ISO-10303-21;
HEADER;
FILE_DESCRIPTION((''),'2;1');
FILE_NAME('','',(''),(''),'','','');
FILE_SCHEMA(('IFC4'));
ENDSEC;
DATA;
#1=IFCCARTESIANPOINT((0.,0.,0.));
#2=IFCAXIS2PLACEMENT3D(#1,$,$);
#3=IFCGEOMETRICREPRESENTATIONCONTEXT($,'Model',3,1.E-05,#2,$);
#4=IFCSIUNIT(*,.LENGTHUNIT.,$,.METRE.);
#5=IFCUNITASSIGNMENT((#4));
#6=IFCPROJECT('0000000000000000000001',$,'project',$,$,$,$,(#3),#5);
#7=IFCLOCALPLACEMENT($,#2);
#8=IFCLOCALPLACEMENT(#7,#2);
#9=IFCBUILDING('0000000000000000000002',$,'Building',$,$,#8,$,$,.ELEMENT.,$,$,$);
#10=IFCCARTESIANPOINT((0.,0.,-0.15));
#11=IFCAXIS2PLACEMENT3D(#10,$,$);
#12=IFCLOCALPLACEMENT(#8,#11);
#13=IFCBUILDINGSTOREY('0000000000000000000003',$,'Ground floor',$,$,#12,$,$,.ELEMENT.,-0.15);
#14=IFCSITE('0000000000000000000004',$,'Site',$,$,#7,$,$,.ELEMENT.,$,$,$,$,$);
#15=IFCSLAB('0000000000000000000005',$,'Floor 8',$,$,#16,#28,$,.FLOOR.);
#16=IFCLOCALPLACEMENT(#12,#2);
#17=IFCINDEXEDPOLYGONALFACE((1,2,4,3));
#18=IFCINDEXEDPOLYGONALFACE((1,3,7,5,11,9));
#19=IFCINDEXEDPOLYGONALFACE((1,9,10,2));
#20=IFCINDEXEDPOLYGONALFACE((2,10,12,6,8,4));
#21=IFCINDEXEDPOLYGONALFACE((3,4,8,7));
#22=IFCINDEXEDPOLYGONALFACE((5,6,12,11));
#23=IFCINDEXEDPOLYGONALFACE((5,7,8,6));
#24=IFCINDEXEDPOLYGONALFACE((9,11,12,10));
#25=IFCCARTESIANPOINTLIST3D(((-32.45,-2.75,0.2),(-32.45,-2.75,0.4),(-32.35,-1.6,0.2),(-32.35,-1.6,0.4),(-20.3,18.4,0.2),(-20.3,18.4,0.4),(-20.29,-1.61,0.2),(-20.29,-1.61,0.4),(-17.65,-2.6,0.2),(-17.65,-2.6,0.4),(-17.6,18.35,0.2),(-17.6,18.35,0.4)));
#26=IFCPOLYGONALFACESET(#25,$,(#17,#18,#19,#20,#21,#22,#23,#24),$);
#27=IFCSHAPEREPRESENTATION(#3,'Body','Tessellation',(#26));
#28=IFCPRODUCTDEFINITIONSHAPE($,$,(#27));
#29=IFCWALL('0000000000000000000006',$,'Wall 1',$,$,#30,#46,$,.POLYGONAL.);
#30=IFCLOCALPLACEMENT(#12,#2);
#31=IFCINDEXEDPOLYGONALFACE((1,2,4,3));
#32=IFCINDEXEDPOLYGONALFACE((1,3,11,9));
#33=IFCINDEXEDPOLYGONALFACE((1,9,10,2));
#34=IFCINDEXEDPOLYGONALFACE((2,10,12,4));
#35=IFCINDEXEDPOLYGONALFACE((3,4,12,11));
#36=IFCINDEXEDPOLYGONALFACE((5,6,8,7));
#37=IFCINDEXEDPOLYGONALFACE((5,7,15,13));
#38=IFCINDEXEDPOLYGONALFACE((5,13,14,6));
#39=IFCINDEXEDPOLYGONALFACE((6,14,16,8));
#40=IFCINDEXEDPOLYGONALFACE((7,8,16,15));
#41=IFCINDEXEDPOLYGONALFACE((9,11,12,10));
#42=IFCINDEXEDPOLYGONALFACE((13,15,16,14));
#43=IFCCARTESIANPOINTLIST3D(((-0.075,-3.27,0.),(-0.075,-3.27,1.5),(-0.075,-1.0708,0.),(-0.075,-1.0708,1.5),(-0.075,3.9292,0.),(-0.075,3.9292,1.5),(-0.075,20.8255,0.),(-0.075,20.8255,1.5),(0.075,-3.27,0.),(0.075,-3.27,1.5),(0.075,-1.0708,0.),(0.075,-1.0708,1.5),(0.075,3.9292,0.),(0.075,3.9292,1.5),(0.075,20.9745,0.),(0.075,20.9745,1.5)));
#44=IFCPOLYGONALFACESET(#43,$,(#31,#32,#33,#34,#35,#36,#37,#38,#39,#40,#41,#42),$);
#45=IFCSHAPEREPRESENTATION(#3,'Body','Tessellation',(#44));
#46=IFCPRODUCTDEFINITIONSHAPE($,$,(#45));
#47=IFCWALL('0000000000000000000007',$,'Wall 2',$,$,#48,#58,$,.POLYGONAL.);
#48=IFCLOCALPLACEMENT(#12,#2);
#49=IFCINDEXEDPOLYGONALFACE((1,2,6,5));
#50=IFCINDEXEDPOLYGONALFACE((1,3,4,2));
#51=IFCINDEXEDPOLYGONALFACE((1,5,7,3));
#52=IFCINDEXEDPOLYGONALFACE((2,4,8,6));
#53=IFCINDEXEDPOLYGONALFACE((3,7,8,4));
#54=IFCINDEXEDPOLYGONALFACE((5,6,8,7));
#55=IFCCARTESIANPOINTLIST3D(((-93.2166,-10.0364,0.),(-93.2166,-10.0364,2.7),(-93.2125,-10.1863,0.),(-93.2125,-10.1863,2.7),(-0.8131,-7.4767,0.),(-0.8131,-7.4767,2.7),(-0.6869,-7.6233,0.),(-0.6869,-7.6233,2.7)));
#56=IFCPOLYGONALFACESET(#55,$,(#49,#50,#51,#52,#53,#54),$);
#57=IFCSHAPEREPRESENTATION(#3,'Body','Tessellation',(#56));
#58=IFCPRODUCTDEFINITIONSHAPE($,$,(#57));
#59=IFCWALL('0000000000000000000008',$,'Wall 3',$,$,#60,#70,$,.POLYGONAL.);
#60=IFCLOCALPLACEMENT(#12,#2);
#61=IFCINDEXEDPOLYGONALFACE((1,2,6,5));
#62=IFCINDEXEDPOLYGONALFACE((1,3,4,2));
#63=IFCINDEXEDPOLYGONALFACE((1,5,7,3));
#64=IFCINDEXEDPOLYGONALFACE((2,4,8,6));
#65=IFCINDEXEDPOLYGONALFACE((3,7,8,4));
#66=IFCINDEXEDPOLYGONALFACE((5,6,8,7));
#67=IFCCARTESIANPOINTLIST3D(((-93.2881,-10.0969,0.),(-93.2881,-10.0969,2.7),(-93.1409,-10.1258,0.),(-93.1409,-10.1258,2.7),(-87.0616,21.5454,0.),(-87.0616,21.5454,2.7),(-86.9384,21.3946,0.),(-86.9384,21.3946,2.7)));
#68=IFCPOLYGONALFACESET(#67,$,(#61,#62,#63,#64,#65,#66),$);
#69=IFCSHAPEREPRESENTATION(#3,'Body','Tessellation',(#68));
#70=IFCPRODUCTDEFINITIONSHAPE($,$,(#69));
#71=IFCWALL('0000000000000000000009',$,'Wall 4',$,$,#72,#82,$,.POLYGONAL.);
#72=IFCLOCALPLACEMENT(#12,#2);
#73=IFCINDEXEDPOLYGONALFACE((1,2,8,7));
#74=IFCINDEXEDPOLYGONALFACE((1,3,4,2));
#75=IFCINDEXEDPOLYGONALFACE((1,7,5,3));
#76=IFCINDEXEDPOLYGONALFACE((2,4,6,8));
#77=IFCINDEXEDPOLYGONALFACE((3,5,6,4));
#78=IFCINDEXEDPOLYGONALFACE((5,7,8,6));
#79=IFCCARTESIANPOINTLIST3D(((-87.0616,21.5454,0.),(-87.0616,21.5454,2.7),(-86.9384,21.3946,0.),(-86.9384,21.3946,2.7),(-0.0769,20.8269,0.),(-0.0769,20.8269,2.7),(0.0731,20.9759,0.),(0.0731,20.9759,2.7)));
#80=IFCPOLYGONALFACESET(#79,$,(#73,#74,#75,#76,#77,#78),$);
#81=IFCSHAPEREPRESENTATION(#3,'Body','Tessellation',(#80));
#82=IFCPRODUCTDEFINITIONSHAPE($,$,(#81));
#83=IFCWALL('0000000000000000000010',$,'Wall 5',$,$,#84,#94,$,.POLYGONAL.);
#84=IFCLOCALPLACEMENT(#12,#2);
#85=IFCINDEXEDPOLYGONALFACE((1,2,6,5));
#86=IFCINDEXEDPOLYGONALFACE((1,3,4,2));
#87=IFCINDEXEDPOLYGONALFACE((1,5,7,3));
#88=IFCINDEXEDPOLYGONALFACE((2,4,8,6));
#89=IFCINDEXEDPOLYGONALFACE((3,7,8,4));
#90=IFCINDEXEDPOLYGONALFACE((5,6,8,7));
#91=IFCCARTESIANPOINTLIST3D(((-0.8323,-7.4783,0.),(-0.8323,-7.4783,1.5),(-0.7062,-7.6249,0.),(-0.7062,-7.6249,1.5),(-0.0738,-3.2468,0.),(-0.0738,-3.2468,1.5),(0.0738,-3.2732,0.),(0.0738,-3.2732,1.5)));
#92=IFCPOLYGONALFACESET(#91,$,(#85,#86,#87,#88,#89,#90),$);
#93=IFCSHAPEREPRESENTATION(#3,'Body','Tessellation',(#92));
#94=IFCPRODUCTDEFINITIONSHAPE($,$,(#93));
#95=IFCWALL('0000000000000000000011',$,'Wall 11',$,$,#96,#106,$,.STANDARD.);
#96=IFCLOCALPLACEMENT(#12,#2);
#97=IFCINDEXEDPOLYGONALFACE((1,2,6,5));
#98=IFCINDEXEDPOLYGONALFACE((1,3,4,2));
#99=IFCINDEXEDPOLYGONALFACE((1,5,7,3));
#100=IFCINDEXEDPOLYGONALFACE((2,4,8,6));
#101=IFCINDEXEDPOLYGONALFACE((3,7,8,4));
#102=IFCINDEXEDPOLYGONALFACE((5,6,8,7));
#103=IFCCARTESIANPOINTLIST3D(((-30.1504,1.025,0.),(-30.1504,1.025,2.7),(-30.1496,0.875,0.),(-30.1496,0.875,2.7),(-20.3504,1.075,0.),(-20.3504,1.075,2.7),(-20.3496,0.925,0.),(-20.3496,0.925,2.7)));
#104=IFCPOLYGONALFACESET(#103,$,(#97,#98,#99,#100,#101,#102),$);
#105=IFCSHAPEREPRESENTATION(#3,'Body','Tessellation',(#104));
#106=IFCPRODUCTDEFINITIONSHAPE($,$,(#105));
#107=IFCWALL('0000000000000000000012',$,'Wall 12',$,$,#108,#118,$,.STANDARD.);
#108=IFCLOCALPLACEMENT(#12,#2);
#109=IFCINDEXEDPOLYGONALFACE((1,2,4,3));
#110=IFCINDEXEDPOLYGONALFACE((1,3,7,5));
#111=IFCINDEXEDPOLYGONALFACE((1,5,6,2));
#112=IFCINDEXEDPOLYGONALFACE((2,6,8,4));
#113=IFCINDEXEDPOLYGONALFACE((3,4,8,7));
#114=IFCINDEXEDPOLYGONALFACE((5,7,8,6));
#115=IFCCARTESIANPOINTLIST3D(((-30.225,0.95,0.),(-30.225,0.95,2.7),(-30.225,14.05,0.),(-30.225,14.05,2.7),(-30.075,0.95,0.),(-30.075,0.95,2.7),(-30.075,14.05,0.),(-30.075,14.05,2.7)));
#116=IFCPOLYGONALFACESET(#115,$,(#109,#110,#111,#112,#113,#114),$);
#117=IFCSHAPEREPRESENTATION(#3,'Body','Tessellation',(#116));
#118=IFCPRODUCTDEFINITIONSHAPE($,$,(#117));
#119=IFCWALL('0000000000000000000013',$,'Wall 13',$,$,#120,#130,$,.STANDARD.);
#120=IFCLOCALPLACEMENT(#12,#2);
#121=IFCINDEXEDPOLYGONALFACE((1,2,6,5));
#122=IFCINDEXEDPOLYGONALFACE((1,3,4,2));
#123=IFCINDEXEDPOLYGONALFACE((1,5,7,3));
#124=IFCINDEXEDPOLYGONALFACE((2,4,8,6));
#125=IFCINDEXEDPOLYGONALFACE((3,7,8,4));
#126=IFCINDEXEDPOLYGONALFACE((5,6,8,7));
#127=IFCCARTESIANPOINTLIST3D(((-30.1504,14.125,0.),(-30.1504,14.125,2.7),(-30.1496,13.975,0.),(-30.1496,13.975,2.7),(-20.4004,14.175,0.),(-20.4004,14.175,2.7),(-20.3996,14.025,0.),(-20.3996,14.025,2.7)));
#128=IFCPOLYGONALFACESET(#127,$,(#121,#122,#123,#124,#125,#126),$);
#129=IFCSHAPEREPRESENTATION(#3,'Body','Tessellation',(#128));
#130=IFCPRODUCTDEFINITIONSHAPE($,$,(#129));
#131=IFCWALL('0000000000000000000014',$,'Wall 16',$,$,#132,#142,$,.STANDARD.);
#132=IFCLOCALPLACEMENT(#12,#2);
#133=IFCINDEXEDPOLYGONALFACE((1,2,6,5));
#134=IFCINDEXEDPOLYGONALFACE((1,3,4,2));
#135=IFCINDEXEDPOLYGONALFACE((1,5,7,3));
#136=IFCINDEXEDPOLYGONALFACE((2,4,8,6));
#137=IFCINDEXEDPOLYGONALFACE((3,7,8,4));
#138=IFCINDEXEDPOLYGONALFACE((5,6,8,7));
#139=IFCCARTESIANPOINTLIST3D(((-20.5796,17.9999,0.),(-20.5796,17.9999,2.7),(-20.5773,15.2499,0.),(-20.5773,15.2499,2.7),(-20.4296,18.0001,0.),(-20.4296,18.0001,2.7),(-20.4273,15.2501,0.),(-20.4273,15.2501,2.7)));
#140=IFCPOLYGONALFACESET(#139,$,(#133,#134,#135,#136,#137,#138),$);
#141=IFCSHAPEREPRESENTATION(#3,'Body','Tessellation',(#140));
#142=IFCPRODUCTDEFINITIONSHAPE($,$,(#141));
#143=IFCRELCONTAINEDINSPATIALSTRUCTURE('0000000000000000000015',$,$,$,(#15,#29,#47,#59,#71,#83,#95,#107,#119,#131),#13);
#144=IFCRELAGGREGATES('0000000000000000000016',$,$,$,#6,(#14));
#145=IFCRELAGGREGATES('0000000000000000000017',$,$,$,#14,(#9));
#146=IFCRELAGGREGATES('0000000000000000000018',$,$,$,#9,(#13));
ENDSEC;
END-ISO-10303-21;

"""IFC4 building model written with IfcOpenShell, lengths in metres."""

from ifc_helpers import new_model, si_unit, frame, frame_2d, origin, origin_with_axes, place, context, project, spatial, polyline, rectangle, outline, extrude, element, save


model = new_model("IFC4")

# Units and contexts
model_context = context("Model", 3, precision=1e-05, world=origin())
ifc_project = project(units=[si_unit("LENGTHUNIT", "METRE")], contexts=[model_context])

# Site, building, storey
site_placement = place(None, origin())
site = spatial("IfcSite", under=ifc_project, at=site_placement, Name="Site", CompositionType="ELEMENT")
building_placement = place(site_placement, origin())
building = spatial("IfcBuilding", under=site, at=building_placement, Name="Building", CompositionType="ELEMENT")
storey_placement = place(building_placement, frame((0.0, 0.0, -0.15)))
storey = spatial("IfcBuildingStorey", under=building, at=storey_placement, Name="Ground floor", CompositionType="ELEMENT", Elevation=-0.15)

# Slab
slab_1_placement = place(storey_placement, frame((0.0, 0.0, 0.2), z_axis=(0.0, 0.0, 1.0), x_axis=(1.0, 0.0, 0.0)))
element("IfcSlab", 1, at=slab_1_placement, inside=storey, Name="Floor 8", PredefinedType="FLOOR", context=model_context, shape_type="SweptSolid", body=[
    extrude(outline(polyline([(-32.45, -2.75), (-32.35, -1.6), (-32.35, -1.6), (-20.29, -1.61), (-20.3, 18.4), (-17.6, 18.35), (-17.65, -2.6), (-32.45, -2.75)])), origin(), (0.0, 0.0, 1.0), 0.2),
])

# Wall, opening
wall_1_placement = place(storey_placement, origin_with_axes())
wall_1 = element("IfcWall", 2, at=wall_1_placement, inside=storey, Name="Wall 1", PredefinedType="POLYGONAL", context=model_context, shape_type="SweptSolid", body=[
    extrude(outline(polyline([(0.075, 20.9745), (-0.075, 20.8255), (-0.075, -3.27), (0.075, -3.27), (0.075, 20.9745)])), origin(), (0.0, 0.0, 1.0), 1.5),
])
opening_1_placement = place(storey_placement, frame((0.0, 3.9292, 0.0), z_axis=(0.0, 0.0, 1.0), x_axis=(0.0, -1.0, 0.0)))
element("IfcOpeningElement", 3, at=opening_1_placement, cuts=wall_1, PredefinedType="OPENING", context=model_context, shape_type="SweptSolid", body=[
    extrude(rectangle(XDim=5.0, YDim=0.21, at=frame_2d((2.5, 0.0))), origin(), (0.0, 0.0, 1.0), 2.1),
])

# Walls
wall_2_placement = place(storey_placement, origin_with_axes())
element("IfcWall", 4, at=wall_2_placement, inside=storey, Name="Wall 2", PredefinedType="POLYGONAL", context=model_context, shape_type="SweptSolid", body=[
    extrude(outline(polyline([(-0.6869, -7.6233), (-0.8131, -7.4767), (-93.2166, -10.0364), (-93.2125, -10.1863), (-0.6869, -7.6233)])), origin(), (0.0, 0.0, 1.0), 2.7),
])
wall_3_placement = place(storey_placement, origin_with_axes())
element("IfcWall", 5, at=wall_3_placement, inside=storey, Name="Wall 3", PredefinedType="POLYGONAL", context=model_context, shape_type="SweptSolid", body=[
    extrude(outline(polyline([(-93.2881, -10.0969), (-93.1409, -10.1258), (-86.9384, 21.3946), (-87.0616, 21.5454), (-93.2881, -10.0969)])), origin(), (0.0, 0.0, 1.0), 2.7),
])
wall_4_placement = place(storey_placement, origin_with_axes())
element("IfcWall", 6, at=wall_4_placement, inside=storey, Name="Wall 4", PredefinedType="POLYGONAL", context=model_context, shape_type="SweptSolid", body=[
    extrude(outline(polyline([(-87.0616, 21.5454), (-86.9384, 21.3946), (-0.0769, 20.8269), (0.0731, 20.9759), (-87.0616, 21.5454)])), origin(), (0.0, 0.0, 1.0), 2.7),
])
wall_5_placement = place(storey_placement, origin_with_axes())
element("IfcWall", 7, at=wall_5_placement, inside=storey, Name="Wall 5", PredefinedType="POLYGONAL", context=model_context, shape_type="SweptSolid", body=[
    extrude(outline(polyline([(0.0738, -3.2732), (-0.0738, -3.2468), (-0.8323, -7.4783), (-0.7062, -7.6249), (0.0738, -3.2732)])), origin(), (0.0, 0.0, 1.0), 1.5),
])

# Walls
wall_6_placement = place(storey_placement, frame((-20.35, 1.0, 0.0), z_axis=(0.0, 0.0, 1.0), x_axis=(-0.999987, -0.005102, 0.0)))
element("IfcWall", 8, at=wall_6_placement, inside=storey, Name="Wall 11", PredefinedType="STANDARD", context=model_context, shape_type="SweptSolid", body=[
    extrude(rectangle(XDim=9.8001, YDim=0.15, at=frame_2d((4.9001, 0.0))), origin(), (0.0, 0.0, 1.0), 2.7),
])
wall_7_placement = place(storey_placement, frame((-30.15, 0.95, 0.0), z_axis=(0.0, 0.0, 1.0), x_axis=(0.0, 1.0, 0.0)))
element("IfcWall", 9, at=wall_7_placement, inside=storey, Name="Wall 12", PredefinedType="STANDARD", context=model_context, shape_type="SweptSolid", body=[
    extrude(rectangle(XDim=13.1, YDim=0.15, at=frame_2d((6.55, 0.0))), origin(), (0.0, 0.0, 1.0), 2.7),
])
wall_8_placement = place(storey_placement, frame((-30.15, 14.05, 0.0), z_axis=(0.0, 0.0, 1.0), x_axis=(0.999987, 0.005128, 0.0)))
element("IfcWall", 10, at=wall_8_placement, inside=storey, Name="Wall 13", PredefinedType="STANDARD", context=model_context, shape_type="SweptSolid", body=[
    extrude(rectangle(XDim=9.7501, YDim=0.15, at=frame_2d((4.8751, 0.0))), origin(), (0.0, 0.0, 1.0), 2.7),
])
wall_9_placement = place(storey_placement, frame((-20.5046, 18.0, 0.0), z_axis=(0.0, 0.0, 1.0), x_axis=(0.000839, -1.0, 0.0)))
element("IfcWall", 11, at=wall_9_placement, inside=storey, Name="Wall 16", PredefinedType="STANDARD", context=model_context, shape_type="SweptSolid", body=[
    extrude(rectangle(XDim=2.75, YDim=0.15, at=frame_2d((1.375, 0.0))), origin(), (0.0, 0.0, 1.0), 2.7),
])

save(model, "model.ifc")
